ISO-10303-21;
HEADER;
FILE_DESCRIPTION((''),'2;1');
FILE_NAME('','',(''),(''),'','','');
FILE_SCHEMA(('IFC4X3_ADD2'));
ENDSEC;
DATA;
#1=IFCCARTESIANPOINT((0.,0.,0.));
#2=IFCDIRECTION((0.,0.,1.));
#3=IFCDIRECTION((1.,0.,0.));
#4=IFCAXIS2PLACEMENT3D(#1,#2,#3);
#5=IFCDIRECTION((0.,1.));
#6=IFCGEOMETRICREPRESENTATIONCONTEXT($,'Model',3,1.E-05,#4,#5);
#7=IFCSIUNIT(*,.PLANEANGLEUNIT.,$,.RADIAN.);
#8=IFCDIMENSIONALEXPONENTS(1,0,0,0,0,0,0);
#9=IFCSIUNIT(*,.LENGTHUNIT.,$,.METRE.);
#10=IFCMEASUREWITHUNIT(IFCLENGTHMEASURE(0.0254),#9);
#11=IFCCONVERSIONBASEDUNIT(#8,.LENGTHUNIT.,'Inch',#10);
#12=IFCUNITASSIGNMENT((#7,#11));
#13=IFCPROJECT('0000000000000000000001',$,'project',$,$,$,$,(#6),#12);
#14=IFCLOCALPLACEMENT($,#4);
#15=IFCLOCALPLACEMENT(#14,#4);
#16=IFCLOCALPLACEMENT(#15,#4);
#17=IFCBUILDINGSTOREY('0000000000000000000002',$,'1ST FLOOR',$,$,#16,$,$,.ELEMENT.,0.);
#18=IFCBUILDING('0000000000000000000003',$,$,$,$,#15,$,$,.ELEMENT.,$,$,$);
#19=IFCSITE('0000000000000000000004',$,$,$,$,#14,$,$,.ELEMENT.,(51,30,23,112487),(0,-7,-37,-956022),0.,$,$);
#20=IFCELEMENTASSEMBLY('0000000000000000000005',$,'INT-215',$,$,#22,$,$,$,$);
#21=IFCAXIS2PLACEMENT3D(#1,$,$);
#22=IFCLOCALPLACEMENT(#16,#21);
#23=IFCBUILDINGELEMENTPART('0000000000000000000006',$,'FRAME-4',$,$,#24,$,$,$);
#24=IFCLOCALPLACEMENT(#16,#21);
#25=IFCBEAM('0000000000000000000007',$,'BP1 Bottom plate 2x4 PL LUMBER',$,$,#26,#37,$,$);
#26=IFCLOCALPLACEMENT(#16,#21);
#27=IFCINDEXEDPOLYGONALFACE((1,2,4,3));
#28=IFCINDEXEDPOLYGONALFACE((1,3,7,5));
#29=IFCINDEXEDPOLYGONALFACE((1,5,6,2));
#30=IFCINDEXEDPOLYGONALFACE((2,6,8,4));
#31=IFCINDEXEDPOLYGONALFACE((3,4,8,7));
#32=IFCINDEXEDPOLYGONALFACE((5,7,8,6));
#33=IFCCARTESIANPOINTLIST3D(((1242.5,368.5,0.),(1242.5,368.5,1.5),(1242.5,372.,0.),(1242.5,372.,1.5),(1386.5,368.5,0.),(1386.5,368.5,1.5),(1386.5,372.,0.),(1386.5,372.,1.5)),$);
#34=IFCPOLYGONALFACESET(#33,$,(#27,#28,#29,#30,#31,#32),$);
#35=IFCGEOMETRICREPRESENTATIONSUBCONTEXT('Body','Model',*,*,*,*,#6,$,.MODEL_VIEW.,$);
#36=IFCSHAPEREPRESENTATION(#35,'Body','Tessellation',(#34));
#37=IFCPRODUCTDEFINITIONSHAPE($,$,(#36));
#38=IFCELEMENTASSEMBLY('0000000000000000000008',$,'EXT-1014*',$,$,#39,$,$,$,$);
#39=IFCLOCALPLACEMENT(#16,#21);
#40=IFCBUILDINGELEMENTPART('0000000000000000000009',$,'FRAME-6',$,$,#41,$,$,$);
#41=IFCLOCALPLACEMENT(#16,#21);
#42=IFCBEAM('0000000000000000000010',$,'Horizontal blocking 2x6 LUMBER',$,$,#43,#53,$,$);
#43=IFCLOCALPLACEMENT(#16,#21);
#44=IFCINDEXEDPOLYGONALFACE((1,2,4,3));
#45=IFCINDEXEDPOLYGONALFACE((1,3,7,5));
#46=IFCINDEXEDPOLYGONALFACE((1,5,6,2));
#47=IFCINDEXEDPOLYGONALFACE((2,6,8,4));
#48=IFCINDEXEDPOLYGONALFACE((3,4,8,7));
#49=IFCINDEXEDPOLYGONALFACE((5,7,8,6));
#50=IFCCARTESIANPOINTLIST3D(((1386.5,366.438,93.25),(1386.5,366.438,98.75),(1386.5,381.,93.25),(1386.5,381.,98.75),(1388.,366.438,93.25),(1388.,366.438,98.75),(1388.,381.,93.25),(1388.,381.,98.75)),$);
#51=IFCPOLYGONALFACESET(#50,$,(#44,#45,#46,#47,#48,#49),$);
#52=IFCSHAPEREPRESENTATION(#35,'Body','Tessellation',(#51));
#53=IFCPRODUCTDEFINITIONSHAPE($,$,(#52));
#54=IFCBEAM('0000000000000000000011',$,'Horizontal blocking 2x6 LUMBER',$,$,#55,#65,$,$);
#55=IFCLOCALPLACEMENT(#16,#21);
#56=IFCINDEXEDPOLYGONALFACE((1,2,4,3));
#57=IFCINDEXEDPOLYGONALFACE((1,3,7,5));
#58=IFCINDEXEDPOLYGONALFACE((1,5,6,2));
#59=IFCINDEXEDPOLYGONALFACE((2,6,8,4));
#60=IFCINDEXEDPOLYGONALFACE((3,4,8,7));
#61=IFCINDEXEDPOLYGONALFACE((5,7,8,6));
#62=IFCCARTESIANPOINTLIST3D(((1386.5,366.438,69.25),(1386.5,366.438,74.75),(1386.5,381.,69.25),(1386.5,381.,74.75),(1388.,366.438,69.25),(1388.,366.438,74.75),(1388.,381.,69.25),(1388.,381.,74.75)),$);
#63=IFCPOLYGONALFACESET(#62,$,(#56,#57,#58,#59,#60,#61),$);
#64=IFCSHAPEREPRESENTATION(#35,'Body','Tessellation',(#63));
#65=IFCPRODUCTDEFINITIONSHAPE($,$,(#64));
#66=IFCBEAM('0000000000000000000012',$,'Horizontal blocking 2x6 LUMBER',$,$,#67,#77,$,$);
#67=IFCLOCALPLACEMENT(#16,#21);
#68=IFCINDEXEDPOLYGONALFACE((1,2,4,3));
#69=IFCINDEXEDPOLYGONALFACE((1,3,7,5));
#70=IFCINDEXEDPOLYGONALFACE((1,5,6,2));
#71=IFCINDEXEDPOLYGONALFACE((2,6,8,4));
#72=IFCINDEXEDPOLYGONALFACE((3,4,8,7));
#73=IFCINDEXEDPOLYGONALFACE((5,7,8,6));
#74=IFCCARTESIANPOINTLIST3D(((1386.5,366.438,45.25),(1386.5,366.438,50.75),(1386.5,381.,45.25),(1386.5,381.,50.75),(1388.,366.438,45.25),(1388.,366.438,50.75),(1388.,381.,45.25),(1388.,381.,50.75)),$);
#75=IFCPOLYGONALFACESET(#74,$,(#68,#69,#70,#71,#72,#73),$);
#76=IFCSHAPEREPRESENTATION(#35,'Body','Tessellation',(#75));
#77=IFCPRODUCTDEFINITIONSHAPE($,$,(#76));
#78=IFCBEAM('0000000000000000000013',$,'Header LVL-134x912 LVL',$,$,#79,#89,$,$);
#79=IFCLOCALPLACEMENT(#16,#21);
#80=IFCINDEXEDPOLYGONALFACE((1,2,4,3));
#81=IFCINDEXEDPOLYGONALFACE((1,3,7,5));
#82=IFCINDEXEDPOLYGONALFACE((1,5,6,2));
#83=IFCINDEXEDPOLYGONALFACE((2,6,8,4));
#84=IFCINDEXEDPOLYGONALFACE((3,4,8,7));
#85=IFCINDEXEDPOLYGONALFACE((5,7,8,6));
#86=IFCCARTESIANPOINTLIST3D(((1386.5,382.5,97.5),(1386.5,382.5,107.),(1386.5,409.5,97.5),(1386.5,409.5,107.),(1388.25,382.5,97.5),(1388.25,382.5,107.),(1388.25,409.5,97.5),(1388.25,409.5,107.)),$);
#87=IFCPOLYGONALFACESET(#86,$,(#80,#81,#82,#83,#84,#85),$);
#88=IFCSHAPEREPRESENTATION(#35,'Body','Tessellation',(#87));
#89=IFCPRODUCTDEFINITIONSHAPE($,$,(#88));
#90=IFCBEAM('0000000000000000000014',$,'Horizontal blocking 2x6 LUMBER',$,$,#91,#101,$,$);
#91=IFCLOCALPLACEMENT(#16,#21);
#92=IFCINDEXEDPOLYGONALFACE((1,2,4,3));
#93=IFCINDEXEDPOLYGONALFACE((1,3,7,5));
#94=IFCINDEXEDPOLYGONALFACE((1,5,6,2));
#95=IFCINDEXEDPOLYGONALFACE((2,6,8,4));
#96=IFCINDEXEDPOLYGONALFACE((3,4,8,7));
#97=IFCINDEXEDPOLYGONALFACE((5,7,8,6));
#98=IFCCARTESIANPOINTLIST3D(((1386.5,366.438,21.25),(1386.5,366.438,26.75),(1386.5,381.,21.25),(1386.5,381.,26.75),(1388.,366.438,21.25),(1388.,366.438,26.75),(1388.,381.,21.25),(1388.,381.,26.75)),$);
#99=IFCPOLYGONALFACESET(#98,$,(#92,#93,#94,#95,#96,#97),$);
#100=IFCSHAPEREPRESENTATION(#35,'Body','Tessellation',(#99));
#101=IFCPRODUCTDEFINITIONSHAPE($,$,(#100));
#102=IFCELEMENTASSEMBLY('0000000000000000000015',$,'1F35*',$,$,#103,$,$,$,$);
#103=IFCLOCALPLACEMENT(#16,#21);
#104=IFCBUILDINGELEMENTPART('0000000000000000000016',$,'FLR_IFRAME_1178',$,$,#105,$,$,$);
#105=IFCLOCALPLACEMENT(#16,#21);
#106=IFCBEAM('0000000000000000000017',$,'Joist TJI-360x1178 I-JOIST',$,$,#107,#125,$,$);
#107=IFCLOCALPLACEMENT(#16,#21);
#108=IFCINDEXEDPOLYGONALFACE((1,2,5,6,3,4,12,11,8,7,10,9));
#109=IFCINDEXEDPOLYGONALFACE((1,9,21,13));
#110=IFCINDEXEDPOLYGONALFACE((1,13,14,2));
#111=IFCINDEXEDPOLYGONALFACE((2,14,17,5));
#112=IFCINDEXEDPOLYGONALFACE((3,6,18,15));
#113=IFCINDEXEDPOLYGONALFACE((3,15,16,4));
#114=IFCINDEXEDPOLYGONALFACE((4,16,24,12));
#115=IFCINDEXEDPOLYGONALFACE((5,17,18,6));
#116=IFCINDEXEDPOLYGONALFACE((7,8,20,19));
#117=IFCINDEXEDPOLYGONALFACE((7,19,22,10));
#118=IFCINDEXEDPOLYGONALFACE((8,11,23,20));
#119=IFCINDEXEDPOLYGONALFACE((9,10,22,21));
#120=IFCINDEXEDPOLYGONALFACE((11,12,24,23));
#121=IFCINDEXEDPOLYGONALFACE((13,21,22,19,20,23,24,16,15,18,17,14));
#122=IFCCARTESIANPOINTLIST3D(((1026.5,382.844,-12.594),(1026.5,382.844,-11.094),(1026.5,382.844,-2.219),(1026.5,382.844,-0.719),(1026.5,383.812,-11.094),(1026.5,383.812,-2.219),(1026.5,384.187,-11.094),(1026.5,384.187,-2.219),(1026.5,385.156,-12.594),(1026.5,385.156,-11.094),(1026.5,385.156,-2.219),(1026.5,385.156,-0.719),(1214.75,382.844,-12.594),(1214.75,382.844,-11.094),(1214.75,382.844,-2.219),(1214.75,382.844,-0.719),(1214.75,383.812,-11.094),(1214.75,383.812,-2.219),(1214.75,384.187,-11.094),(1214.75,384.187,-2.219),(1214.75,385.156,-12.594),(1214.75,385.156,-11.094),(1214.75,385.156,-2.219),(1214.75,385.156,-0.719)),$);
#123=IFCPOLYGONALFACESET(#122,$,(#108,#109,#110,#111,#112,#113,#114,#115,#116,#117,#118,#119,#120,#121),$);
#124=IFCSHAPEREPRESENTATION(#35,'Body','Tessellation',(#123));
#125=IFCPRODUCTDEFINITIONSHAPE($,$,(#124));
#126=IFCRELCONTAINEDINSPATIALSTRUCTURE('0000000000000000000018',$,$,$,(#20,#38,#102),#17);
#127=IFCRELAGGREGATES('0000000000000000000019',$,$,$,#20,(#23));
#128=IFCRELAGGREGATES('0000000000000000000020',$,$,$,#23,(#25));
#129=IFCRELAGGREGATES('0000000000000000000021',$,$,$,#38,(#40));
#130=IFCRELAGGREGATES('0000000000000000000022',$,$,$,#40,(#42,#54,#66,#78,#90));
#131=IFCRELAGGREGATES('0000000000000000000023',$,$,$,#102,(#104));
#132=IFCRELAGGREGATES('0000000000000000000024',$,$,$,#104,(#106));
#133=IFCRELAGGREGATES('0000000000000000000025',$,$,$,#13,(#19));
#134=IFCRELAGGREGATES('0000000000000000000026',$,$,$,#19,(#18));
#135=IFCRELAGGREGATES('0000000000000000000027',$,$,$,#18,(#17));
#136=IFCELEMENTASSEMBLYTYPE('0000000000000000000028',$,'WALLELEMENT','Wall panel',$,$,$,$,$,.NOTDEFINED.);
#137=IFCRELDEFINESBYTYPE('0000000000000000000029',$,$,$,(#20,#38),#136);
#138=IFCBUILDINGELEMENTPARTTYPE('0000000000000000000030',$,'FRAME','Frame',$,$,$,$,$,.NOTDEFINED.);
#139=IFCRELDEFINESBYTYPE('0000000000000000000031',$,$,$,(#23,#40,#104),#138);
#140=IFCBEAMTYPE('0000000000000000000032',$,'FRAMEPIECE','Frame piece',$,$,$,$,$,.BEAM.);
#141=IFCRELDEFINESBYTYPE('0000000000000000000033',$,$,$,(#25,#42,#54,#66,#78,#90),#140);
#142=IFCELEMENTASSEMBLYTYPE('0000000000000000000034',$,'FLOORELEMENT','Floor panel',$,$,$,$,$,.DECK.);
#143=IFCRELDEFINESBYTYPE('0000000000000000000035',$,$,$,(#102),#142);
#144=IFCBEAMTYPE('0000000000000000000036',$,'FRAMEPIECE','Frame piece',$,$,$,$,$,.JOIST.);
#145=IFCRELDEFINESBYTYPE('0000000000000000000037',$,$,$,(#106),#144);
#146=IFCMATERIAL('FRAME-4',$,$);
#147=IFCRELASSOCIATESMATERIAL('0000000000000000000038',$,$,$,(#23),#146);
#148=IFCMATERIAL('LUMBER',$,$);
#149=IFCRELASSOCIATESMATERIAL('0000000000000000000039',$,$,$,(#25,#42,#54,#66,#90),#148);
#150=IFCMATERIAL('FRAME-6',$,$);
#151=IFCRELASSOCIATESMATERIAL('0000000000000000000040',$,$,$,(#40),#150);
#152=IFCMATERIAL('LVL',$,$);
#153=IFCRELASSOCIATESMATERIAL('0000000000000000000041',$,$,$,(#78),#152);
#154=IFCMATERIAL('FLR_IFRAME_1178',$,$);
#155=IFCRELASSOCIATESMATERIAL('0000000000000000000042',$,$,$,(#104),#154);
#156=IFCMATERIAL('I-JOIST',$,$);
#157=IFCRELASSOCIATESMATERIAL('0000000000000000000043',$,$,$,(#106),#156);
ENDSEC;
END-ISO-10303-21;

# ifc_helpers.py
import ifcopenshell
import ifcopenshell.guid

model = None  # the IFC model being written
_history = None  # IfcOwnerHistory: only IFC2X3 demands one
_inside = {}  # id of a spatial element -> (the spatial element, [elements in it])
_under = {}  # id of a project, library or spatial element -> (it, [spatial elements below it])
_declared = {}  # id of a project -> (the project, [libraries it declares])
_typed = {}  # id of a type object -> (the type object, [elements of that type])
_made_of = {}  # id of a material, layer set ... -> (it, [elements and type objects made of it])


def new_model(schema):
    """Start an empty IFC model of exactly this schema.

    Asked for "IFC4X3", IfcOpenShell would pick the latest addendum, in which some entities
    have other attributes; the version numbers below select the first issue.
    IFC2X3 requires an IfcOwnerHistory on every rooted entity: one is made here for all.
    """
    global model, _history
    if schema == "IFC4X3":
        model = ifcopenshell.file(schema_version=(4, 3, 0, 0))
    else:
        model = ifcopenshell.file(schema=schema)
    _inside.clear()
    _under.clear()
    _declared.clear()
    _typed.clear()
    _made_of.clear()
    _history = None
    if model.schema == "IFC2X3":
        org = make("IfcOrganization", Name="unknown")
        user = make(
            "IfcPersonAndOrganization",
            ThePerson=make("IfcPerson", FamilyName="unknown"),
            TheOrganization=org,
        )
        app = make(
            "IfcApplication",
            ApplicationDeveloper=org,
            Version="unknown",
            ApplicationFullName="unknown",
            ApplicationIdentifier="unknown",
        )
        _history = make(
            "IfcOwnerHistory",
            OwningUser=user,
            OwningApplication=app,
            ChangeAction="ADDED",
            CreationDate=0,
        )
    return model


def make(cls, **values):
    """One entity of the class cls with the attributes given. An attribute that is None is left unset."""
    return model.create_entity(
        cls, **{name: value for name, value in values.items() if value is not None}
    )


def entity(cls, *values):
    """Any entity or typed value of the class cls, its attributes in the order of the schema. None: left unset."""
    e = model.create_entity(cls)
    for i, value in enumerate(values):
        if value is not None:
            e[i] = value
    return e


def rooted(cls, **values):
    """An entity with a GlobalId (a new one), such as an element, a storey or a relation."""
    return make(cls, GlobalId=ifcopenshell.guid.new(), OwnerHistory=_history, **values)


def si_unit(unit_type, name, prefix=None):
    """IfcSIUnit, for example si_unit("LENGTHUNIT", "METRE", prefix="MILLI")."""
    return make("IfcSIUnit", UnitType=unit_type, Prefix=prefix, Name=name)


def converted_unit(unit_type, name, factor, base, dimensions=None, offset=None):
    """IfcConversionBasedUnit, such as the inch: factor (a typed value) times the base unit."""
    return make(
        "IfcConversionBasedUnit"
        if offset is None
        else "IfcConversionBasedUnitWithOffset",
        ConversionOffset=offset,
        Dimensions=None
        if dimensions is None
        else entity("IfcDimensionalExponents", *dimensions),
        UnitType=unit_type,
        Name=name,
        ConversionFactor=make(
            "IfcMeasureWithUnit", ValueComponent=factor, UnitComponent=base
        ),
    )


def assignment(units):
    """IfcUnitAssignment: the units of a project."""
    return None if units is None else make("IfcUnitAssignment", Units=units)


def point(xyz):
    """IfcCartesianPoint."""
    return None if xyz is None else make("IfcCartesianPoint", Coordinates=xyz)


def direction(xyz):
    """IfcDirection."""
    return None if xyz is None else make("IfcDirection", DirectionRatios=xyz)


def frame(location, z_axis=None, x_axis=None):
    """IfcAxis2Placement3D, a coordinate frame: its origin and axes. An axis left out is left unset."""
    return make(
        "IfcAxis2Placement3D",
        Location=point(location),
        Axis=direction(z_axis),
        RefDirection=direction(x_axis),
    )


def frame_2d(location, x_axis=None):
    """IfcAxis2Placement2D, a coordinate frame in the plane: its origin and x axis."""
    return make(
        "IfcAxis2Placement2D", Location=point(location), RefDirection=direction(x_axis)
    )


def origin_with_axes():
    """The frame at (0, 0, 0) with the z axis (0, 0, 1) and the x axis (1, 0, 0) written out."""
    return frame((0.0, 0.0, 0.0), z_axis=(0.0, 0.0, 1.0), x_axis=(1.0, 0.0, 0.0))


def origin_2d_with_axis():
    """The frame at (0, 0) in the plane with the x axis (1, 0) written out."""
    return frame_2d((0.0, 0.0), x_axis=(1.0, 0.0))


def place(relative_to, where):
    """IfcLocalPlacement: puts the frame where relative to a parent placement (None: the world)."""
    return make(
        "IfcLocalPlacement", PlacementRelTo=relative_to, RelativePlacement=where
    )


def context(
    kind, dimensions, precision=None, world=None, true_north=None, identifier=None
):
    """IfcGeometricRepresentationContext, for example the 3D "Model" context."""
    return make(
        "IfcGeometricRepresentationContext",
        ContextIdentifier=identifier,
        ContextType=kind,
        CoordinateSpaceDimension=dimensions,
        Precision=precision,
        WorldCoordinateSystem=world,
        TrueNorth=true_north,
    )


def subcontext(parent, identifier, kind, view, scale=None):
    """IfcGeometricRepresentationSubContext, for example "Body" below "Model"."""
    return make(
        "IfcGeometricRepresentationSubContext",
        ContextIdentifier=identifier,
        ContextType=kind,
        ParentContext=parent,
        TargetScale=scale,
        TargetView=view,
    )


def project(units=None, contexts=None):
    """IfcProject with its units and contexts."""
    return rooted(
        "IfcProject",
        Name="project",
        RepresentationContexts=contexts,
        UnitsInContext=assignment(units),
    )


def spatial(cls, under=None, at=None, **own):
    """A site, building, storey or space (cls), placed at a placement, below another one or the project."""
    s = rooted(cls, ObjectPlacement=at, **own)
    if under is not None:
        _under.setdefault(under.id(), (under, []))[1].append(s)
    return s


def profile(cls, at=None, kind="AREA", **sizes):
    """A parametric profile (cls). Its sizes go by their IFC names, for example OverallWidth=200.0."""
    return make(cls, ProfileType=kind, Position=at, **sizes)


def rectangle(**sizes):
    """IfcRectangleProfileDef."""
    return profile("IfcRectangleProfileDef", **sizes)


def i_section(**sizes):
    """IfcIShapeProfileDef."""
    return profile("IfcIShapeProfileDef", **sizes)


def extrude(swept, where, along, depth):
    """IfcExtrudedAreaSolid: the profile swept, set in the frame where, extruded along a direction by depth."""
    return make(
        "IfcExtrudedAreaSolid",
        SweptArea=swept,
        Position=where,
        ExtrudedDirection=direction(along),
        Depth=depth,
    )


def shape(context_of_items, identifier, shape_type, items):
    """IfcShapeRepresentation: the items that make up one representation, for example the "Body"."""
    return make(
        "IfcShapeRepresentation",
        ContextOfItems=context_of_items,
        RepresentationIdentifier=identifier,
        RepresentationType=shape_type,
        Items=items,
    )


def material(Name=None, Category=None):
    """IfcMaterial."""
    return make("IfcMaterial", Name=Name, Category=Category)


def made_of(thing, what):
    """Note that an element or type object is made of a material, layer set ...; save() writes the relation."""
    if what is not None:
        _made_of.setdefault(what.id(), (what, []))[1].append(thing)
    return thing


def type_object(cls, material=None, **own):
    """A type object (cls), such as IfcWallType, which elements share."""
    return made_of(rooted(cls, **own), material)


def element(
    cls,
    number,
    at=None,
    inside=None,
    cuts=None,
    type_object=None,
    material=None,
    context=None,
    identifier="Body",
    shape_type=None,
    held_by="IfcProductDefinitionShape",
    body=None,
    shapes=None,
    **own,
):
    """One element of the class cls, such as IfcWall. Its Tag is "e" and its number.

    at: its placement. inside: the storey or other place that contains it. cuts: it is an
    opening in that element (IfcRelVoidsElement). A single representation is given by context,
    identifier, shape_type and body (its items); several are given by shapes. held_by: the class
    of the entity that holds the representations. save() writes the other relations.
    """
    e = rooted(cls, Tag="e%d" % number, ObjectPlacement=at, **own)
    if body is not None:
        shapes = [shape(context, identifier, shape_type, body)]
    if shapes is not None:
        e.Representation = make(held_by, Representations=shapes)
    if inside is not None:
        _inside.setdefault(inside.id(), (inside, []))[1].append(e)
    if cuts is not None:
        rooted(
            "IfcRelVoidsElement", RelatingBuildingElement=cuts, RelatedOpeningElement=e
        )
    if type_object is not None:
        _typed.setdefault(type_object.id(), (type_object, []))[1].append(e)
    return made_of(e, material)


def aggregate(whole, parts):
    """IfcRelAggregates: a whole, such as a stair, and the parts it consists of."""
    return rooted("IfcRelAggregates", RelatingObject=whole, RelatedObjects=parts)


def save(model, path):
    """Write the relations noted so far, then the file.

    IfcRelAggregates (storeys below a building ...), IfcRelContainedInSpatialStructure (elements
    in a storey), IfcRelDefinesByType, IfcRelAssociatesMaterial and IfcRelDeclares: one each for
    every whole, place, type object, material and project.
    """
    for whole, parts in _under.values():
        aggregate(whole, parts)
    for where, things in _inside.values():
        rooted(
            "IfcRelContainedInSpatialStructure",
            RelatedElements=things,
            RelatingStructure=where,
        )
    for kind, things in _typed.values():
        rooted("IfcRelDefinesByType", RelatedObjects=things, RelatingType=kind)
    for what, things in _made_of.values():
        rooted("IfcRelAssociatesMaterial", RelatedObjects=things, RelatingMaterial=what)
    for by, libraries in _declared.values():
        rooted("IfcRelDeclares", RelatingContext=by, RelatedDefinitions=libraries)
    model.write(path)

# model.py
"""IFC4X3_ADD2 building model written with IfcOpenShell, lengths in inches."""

from ifc_helpers import new_model, entity, si_unit, converted_unit, direction, frame, origin_with_axes, origin_2d_with_axis, place, context, subcontext, project, spatial, rectangle, i_section, extrude, material, type_object, element, aggregate, save


model = new_model("IFC4X3_ADD2")

# Units and contexts
model_context = context("Model", 3, precision=1e-05, world=origin_with_axes(), true_north=direction((0.0, 1.0)))
body_context = subcontext(model_context, "Body", "Model", "MODEL_VIEW")
ifc_project = project(units=[si_unit("PLANEANGLEUNIT", "RADIAN"), converted_unit("LENGTHUNIT", "Inch", entity("IfcLengthMeasure", 0.0254), si_unit("LENGTHUNIT", "METRE"), dimensions=[1, 0, 0, 0, 0, 0, 0])], contexts=[model_context])

# Site, building, storey
site_placement = place(None, origin_with_axes())
site = spatial("IfcSite", under=ifc_project, at=site_placement, CompositionType="ELEMENT", RefLatitude=(51, 30, 23, 112487), RefLongitude=(0, -7, -37, -956022), RefElevation=0.0)
building_placement = place(site_placement, origin_with_axes())
building = spatial("IfcBuilding", under=site, at=building_placement, CompositionType="ELEMENT")
storey_placement = place(building_placement, origin_with_axes())
storey = spatial("IfcBuildingStorey", under=building, at=storey_placement, Name="1ST FLOOR", CompositionType="ELEMENT", Elevation=0.0)

# Element assembly, building element part
element_assembly_type_1 = type_object("IfcElementAssemblyType", Name="WALLELEMENT", Description="Wall panel", PredefinedType="NOTDEFINED")
assembly_1_placement = place(storey_placement, origin_with_axes())
assembly_1 = element("IfcElementAssembly", 1, at=assembly_1_placement, inside=storey, type_object=element_assembly_type_1, Name="INT-215")
ifc_material_1 = material(Name="FRAME-4")
building_element_part_type = type_object("IfcBuildingElementPartType", Name="FRAME", Description="Frame", PredefinedType="NOTDEFINED")
building_element_part_1_placement = place(storey_placement, origin_with_axes())
building_element_part_1 = element("IfcBuildingElementPart", 2, at=building_element_part_1_placement, type_object=building_element_part_type, material=ifc_material_1, Name="FRAME-4")
aggregate(assembly_1, [building_element_part_1])
ifc_material_2 = material(Name="LUMBER")

# Shared definitions
element_assembly_type_2 = type_object("IfcElementAssemblyType", Name="FLOORELEMENT", Description="Floor panel", PredefinedType="DECK")
ifc_material_3 = material(Name="FLR_IFRAME_1178")
beam_type_1 = type_object("IfcBeamType", Name="FRAMEPIECE", Description="Frame piece", PredefinedType="BEAM")

# Beam
beam_1_placement = place(storey_placement, frame((1386.5, 370.25, 0.75), z_axis=(-1.0, 0.0, 0.0), x_axis=(0.0, 0.0, 1.0)))
beam_1 = element("IfcBeam", 3, at=beam_1_placement, type_object=beam_type_1, material=ifc_material_2, Name="BP1 Bottom plate 2x4 PL LUMBER", context=body_context, shape_type="SweptSolid", body=[
    extrude(rectangle(XDim=1.5, YDim=3.5, at=origin_2d_with_axis()), origin_with_axes(), (0.0, 0.0, 1.0), 144.0),
])
aggregate(building_element_part_1, [beam_1])

# Element assembly, building element part, beams
assembly_2_placement = place(storey_placement, origin_with_axes())
assembly_2 = element("IfcElementAssembly", 4, at=assembly_2_placement, inside=storey, type_object=element_assembly_type_1, Name="EXT-1014*")
ifc_material_4 = material(Name="FRAME-6")
building_element_part_2_placement = place(storey_placement, origin_with_axes())
building_element_part_2 = element("IfcBuildingElementPart", 5, at=building_element_part_2_placement, type_object=building_element_part_type, material=ifc_material_4, Name="FRAME-6")
aggregate(assembly_2, [building_element_part_2])
beam_2_placement = place(storey_placement, frame((1387.25, 381.0, 96.0), z_axis=(0.0, -1.0, 0.0), x_axis=(-1.0, 0.0, 0.0)))
beam_2 = element("IfcBeam", 6, at=beam_2_placement, type_object=beam_type_1, material=ifc_material_2, Name="Horizontal blocking 2x6 LUMBER", context=body_context, shape_type="SweptSolid", body=[
    extrude(rectangle(XDim=1.5, YDim=5.5, at=origin_2d_with_axis()), origin_with_axes(), (0.0, 0.0, 1.0), 14.562),
])
beam_3_placement = place(storey_placement, frame((1387.25, 381.0, 72.0), z_axis=(0.0, -1.0, 0.0), x_axis=(-1.0, 0.0, 0.0)))
beam_3 = element("IfcBeam", 7, at=beam_3_placement, type_object=beam_type_1, material=ifc_material_2, Name="Horizontal blocking 2x6 LUMBER", context=body_context, shape_type="SweptSolid", body=[
    extrude(rectangle(XDim=1.5, YDim=5.5, at=origin_2d_with_axis()), origin_with_axes(), (0.0, 0.0, 1.0), 14.562),
])
beam_4_placement = place(storey_placement, frame((1387.25, 381.0, 48.0), z_axis=(0.0, -1.0, 0.0), x_axis=(-1.0, 0.0, 0.0)))
beam_4 = element("IfcBeam", 8, at=beam_4_placement, type_object=beam_type_1, material=ifc_material_2, Name="Horizontal blocking 2x6 LUMBER", context=body_context, shape_type="SweptSolid", body=[
    extrude(rectangle(XDim=1.5, YDim=5.5, at=origin_2d_with_axis()), origin_with_axes(), (0.0, 0.0, 1.0), 14.562),
])
ifc_material_5 = material(Name="LVL")
beam_5_placement = place(storey_placement, frame((1387.375, 382.5, 102.25), z_axis=(0.0, 1.0, 0.0), x_axis=(-1.0, 0.0, 0.0)))
beam_5 = element("IfcBeam", 9, at=beam_5_placement, type_object=beam_type_1, material=ifc_material_5, Name="Header LVL-134x912 LVL", context=body_context, shape_type="SweptSolid", body=[
    extrude(rectangle(XDim=1.75, YDim=9.5, at=origin_2d_with_axis()), origin_with_axes(), (0.0, 0.0, 1.0), 27.0),
])
beam_6_placement = place(storey_placement, frame((1387.25, 381.0, 24.0), z_axis=(0.0, -1.0, 0.0), x_axis=(-1.0, 0.0, 0.0)))
beam_6 = element("IfcBeam", 10, at=beam_6_placement, type_object=beam_type_1, material=ifc_material_2, Name="Horizontal blocking 2x6 LUMBER", context=body_context, shape_type="SweptSolid", body=[
    extrude(rectangle(XDim=1.5, YDim=5.5, at=origin_2d_with_axis()), origin_with_axes(), (0.0, 0.0, 1.0), 14.562),
])
aggregate(building_element_part_2, [beam_2, beam_3, beam_4, beam_5, beam_6])

# Element assembly, building element part, beam
assembly_3_placement = place(storey_placement, origin_with_axes())
assembly_3 = element("IfcElementAssembly", 11, at=assembly_3_placement, inside=storey, type_object=element_assembly_type_2, Name="1F35*")
building_element_part_3_placement = place(storey_placement, origin_with_axes())
building_element_part_3 = element("IfcBuildingElementPart", 12, at=building_element_part_3_placement, type_object=building_element_part_type, material=ifc_material_3, Name="FLR_IFRAME_1178")
aggregate(assembly_3, [building_element_part_3])
ifc_material_6 = material(Name="I-JOIST")
beam_type_2 = type_object("IfcBeamType", Name="FRAMEPIECE", Description="Frame piece", PredefinedType="JOIST")
beam_7_placement = place(storey_placement, frame((1214.75, 384.0, -6.656), z_axis=(-1.0, 0.0, 0.0), x_axis=(0.0, -1.0, 0.0)))
beam_7 = element("IfcBeam", 13, at=beam_7_placement, type_object=beam_type_2, material=ifc_material_6, Name="Joist TJI-360x1178 I-JOIST", context=body_context, shape_type="SweptSolid", body=[
    extrude(i_section(OverallWidth=2.313, OverallDepth=11.875, WebThickness=0.375, FlangeThickness=1.5, at=origin_2d_with_axis()), origin_with_axes(), (0.0, 0.0, 1.0), 188.25),
])
aggregate(building_element_part_3, [beam_7])

save(model, "model.ifc")
